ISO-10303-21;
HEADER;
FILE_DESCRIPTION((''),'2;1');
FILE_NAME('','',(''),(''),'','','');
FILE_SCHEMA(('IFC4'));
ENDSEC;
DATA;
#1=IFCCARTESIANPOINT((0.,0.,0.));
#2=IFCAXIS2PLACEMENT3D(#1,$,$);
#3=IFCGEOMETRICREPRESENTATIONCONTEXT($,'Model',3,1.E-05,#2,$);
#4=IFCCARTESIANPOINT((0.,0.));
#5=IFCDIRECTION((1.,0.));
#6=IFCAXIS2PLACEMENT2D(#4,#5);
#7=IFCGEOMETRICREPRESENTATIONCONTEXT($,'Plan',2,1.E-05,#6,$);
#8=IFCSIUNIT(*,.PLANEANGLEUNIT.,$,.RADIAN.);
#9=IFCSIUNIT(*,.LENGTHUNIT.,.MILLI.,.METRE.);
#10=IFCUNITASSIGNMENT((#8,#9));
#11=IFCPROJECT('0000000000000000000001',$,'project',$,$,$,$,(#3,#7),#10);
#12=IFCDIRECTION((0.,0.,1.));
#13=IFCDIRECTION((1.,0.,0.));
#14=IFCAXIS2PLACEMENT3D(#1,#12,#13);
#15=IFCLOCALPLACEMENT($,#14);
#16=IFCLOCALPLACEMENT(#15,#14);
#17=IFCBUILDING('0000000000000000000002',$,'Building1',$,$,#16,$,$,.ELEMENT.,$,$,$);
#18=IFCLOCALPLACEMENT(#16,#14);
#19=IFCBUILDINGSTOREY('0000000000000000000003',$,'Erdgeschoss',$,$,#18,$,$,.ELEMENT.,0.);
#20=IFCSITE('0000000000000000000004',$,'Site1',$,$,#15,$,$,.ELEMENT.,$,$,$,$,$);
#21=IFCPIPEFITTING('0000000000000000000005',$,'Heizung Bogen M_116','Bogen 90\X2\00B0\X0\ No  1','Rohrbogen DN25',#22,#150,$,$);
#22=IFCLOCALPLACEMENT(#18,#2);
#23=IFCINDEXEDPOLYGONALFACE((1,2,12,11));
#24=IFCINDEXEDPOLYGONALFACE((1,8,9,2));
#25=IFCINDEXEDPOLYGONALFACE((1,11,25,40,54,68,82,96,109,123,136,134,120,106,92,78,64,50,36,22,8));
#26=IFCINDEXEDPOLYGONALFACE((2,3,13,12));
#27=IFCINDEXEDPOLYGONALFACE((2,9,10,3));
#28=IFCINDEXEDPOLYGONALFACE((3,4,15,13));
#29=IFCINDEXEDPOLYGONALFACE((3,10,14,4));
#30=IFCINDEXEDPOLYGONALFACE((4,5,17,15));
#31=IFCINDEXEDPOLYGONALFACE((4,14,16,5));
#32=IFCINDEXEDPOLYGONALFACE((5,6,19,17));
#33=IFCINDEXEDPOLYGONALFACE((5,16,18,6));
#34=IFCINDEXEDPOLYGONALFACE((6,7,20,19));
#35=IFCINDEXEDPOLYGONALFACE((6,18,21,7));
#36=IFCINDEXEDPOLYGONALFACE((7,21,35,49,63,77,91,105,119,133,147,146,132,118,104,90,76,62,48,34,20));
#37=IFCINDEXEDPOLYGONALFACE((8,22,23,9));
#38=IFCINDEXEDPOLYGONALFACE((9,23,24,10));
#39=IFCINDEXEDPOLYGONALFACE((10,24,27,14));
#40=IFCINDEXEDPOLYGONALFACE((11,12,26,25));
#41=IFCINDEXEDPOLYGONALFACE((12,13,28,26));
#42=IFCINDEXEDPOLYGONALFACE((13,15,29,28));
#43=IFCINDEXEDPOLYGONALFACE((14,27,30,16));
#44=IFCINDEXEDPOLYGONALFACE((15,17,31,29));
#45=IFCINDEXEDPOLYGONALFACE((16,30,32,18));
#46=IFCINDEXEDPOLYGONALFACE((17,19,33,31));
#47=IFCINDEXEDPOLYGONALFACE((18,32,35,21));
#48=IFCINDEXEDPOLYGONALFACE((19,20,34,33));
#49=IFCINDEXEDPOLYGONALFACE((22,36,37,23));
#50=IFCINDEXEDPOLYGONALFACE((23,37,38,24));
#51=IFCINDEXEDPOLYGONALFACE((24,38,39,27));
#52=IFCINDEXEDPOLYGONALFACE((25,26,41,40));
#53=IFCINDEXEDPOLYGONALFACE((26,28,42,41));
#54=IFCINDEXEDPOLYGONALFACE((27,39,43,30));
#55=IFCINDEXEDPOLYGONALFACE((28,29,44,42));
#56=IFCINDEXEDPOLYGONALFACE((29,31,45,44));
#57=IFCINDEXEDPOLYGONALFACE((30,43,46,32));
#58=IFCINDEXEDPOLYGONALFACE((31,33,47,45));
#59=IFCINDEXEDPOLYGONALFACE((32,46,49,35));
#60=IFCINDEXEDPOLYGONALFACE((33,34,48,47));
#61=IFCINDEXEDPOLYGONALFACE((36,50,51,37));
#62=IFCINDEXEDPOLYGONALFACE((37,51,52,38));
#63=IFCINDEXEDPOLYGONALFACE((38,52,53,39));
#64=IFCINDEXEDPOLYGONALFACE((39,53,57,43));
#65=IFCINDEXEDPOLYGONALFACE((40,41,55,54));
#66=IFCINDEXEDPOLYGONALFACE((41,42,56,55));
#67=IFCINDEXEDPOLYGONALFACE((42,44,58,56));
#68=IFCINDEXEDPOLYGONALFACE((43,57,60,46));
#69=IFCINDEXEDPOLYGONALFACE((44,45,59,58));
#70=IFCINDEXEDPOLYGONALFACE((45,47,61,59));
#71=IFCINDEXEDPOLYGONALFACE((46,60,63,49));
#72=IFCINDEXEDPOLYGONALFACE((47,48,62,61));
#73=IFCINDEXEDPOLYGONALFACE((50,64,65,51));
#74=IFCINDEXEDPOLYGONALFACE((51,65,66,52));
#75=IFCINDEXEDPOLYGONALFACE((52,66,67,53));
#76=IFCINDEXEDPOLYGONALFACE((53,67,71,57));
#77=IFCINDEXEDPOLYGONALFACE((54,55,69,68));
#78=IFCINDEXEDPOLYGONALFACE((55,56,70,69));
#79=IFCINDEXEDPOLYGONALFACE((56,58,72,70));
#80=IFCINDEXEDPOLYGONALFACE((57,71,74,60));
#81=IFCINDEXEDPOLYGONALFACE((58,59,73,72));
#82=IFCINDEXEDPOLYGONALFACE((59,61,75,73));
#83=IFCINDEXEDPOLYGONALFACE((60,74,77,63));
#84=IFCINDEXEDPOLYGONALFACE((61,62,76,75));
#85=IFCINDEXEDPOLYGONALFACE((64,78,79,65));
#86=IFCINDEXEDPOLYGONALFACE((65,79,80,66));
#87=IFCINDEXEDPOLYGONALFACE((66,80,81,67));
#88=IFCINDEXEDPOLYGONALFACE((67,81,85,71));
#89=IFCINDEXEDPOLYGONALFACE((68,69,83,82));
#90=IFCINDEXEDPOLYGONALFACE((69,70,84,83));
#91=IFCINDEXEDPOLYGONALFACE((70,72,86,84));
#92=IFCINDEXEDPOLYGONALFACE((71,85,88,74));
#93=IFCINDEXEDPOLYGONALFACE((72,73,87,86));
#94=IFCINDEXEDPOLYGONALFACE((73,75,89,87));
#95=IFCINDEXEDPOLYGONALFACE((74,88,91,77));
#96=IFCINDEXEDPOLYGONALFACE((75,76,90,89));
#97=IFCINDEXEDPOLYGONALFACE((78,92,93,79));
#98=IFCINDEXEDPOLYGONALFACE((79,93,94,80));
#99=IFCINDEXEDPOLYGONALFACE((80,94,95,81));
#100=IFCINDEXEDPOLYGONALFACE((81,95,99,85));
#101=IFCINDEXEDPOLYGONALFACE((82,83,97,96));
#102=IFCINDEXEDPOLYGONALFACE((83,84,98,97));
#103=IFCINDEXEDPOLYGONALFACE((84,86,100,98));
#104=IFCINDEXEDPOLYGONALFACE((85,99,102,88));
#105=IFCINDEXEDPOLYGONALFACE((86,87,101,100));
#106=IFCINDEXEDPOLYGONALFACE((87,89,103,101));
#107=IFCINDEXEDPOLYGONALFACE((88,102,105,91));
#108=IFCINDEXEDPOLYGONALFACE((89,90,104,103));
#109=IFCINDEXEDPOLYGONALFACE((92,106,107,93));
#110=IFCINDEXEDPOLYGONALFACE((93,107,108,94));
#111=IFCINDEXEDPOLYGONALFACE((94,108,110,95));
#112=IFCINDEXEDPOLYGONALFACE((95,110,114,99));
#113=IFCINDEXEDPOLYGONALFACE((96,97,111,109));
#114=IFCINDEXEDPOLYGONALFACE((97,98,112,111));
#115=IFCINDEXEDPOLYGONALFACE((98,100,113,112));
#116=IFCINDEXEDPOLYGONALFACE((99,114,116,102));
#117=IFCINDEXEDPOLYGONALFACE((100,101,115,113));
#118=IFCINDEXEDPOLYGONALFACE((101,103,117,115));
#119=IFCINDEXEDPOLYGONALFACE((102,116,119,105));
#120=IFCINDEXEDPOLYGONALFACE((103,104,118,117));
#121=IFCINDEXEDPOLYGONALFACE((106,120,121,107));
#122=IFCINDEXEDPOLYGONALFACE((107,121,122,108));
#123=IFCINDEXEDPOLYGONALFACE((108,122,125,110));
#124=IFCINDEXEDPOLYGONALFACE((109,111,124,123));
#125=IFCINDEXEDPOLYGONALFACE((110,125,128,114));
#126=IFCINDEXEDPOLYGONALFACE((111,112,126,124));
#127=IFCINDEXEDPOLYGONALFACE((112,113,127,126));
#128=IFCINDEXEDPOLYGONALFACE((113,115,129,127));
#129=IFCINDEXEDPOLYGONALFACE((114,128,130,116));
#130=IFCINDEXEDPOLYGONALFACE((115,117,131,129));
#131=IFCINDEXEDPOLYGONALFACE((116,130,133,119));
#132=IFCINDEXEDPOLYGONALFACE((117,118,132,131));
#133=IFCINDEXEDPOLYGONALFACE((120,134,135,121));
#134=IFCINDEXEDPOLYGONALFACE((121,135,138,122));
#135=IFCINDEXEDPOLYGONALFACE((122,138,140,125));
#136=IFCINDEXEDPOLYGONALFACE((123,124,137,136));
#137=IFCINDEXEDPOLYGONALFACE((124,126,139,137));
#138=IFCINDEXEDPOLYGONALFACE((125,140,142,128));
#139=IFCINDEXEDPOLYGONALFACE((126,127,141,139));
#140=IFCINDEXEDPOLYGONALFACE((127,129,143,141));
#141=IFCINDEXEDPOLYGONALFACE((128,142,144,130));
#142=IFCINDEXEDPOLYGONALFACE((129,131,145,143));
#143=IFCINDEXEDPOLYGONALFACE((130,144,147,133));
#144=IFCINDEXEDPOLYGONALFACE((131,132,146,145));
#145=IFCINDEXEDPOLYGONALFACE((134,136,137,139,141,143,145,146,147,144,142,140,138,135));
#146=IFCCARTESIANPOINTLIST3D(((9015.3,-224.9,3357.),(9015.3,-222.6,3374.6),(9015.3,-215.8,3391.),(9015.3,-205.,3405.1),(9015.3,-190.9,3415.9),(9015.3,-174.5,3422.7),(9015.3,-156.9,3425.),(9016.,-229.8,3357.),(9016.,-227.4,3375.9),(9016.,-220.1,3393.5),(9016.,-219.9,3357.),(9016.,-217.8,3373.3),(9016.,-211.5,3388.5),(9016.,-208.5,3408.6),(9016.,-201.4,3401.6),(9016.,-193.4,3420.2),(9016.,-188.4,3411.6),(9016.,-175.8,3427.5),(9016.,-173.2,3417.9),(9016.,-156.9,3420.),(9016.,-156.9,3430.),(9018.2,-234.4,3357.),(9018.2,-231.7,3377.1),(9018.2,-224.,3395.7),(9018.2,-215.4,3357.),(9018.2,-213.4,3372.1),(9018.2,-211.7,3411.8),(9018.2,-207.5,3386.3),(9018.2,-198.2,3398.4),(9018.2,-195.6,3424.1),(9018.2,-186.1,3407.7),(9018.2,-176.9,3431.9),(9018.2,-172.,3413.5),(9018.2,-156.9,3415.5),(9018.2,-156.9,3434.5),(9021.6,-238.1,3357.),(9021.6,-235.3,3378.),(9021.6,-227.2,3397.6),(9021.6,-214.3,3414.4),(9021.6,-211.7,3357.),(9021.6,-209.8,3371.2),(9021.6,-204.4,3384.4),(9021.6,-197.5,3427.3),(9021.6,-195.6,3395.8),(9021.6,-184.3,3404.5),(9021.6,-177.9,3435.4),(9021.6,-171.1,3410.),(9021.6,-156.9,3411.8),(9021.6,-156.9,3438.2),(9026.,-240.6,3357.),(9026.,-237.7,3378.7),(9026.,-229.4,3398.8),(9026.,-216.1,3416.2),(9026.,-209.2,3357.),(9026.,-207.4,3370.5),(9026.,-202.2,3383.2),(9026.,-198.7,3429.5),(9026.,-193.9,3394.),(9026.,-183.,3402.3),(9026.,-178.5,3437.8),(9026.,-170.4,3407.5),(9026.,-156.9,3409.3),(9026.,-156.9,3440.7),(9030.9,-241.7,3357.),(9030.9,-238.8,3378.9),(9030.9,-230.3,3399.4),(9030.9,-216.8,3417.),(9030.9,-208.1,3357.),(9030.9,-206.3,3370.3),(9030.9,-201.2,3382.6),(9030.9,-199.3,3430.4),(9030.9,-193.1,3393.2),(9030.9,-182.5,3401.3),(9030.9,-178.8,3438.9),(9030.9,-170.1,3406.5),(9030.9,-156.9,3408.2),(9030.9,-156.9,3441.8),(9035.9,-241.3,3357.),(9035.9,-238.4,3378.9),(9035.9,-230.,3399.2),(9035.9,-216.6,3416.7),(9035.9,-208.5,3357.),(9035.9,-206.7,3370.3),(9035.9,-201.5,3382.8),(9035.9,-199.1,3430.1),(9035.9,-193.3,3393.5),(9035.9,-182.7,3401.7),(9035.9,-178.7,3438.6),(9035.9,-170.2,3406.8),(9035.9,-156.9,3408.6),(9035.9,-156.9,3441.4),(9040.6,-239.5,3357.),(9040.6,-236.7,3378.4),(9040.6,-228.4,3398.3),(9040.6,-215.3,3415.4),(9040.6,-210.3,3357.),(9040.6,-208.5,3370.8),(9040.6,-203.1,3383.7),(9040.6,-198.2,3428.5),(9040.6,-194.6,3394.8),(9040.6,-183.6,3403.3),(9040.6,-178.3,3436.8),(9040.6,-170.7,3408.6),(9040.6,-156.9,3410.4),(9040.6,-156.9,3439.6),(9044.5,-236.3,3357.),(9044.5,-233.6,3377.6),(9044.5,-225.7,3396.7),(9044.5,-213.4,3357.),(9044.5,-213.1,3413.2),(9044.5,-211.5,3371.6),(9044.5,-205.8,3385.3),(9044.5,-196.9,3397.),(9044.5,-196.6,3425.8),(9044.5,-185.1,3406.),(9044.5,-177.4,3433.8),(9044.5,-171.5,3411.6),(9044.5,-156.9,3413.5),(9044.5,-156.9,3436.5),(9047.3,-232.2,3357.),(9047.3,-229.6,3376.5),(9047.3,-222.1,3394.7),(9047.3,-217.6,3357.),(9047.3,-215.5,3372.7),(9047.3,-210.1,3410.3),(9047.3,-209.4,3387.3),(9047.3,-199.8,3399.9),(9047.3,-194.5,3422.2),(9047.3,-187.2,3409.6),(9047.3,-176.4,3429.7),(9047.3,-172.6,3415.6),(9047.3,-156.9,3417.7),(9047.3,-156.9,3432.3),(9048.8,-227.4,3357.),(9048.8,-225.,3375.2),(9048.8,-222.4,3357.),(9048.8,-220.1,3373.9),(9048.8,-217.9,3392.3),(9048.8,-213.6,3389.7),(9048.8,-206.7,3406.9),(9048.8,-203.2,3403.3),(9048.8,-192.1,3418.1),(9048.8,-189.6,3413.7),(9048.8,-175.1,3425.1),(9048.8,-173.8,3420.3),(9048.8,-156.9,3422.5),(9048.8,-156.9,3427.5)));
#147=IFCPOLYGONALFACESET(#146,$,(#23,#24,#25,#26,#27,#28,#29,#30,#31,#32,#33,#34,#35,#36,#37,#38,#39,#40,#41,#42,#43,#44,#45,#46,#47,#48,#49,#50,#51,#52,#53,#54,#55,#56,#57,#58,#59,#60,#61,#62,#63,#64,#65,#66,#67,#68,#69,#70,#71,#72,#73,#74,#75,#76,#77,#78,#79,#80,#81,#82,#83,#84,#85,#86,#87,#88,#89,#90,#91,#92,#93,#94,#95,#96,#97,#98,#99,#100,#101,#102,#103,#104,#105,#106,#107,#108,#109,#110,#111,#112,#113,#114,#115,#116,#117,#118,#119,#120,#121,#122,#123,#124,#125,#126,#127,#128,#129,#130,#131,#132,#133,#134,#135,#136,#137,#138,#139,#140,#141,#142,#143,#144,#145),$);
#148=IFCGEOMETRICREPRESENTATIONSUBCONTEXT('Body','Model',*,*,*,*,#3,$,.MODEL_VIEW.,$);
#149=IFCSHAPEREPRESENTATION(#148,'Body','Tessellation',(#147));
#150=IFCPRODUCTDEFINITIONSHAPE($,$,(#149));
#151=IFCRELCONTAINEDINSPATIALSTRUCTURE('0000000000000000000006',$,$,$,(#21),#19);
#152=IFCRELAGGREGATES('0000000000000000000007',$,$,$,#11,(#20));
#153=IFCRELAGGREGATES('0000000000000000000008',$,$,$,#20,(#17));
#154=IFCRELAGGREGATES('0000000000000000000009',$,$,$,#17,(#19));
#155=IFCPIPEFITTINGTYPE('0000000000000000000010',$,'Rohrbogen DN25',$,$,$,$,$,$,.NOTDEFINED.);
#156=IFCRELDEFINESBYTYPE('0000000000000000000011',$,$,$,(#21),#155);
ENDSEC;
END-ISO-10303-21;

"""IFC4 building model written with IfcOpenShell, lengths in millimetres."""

from ifc_helpers import new_model, entity, si_unit, frame, origin, origin_with_axes, origin_2d_with_axis, place, context, subcontext, project, spatial, shape, source, transform, mapped, type_object, element, save


model = new_model("IFC4")

# Units and contexts
model_context = context("Model", 3, precision=1e-05, world=origin())
plan_context = context("Plan", 2, precision=1e-05, world=origin_2d_with_axis())
body_context = subcontext(model_context, "Body", "Model", "MODEL_VIEW")
ifc_project = project(units=[si_unit("PLANEANGLEUNIT", "RADIAN"), si_unit("LENGTHUNIT", "METRE", prefix="MILLI")], contexts=[model_context, plan_context])

# Site, building, storey
site_placement = place(None, origin_with_axes())
site = spatial("IfcSite", under=ifc_project, at=site_placement, Name="Site1", CompositionType="ELEMENT")
building_placement = place(site_placement, origin_with_axes())
building = spatial("IfcBuilding", under=site, at=building_placement, Name="Building1", CompositionType="ELEMENT")
storey_placement = place(building_placement, origin_with_axes())
storey = spatial("IfcBuildingStorey", under=building, at=storey_placement, Name="Erdgeschoss", CompositionType="ELEMENT", Elevation=0.0)

# Pipe fitting
pipe_fitting_type_1 = type_object("IfcPipeFittingType", Name="Rohrbogen DN25", PredefinedType="NOTDEFINED")
shared_shape_1 = source(origin_with_axes(), body_context, "Body", "SolidModel", [
    entity("IfcRevolvedAreaSolid", entity("IfcCircleProfileDef", "AREA", None, entity("IfcAxis2Placement2D", entity("IfcCartesianPoint", [0.0, 0.0]), entity("IfcDirection", [1.0, 0.0])), 16.9), entity("IfcAxis2Placement3D", entity("IfcCartesianPoint", [-42.4, 0.0, 25.6]), entity("IfcDirection", [1.0, 0.0, 0.0]), entity("IfcDirection", [0.0, -1.0, 0.0])), entity("IfcAxis1Placement", entity("IfcCartesianPoint", [0.0, 68.0, 0.0]), entity("IfcDirection", [-1.0, 0.0, 0.0])), 1.570796),
])
pipe_fitting_1_placement = place(storey_placement, frame((9032.1, -199.3, 3399.4), z_axis=(0.0, 0.0, 1.0), x_axis=(1.0, 0.0, 0.0)))
element("IfcPipeFitting", 1, at=pipe_fitting_1_placement, inside=storey, type_object=pipe_fitting_type_1, Name="Heizung Bogen M_116", Description="Bogen 90° No  1", ObjectType="Rohrbogen DN25", shapes=[
    shape(body_context, "Body", "MappedRepresentation", [mapped(shared_shape_1, transform((0.0, 0.0, 0.0), x_axis=(0.0, -1.0, 0.0), y_axis=(1.0, 0.0, 0.0), z_axis=(0.0, 0.0, 1.0), scale=1.0))]),
    shape(body_context, "Body", "MappedRepresentation", [mapped(shared_shape_1, transform((0.0, 0.0, 0.0), x_axis=(0.0, -1.0, 0.0), y_axis=(1.0, 0.0, 0.0), z_axis=(0.0, 0.0, 1.0), scale=1.0))]),
])

save(model, "model.ifc")
